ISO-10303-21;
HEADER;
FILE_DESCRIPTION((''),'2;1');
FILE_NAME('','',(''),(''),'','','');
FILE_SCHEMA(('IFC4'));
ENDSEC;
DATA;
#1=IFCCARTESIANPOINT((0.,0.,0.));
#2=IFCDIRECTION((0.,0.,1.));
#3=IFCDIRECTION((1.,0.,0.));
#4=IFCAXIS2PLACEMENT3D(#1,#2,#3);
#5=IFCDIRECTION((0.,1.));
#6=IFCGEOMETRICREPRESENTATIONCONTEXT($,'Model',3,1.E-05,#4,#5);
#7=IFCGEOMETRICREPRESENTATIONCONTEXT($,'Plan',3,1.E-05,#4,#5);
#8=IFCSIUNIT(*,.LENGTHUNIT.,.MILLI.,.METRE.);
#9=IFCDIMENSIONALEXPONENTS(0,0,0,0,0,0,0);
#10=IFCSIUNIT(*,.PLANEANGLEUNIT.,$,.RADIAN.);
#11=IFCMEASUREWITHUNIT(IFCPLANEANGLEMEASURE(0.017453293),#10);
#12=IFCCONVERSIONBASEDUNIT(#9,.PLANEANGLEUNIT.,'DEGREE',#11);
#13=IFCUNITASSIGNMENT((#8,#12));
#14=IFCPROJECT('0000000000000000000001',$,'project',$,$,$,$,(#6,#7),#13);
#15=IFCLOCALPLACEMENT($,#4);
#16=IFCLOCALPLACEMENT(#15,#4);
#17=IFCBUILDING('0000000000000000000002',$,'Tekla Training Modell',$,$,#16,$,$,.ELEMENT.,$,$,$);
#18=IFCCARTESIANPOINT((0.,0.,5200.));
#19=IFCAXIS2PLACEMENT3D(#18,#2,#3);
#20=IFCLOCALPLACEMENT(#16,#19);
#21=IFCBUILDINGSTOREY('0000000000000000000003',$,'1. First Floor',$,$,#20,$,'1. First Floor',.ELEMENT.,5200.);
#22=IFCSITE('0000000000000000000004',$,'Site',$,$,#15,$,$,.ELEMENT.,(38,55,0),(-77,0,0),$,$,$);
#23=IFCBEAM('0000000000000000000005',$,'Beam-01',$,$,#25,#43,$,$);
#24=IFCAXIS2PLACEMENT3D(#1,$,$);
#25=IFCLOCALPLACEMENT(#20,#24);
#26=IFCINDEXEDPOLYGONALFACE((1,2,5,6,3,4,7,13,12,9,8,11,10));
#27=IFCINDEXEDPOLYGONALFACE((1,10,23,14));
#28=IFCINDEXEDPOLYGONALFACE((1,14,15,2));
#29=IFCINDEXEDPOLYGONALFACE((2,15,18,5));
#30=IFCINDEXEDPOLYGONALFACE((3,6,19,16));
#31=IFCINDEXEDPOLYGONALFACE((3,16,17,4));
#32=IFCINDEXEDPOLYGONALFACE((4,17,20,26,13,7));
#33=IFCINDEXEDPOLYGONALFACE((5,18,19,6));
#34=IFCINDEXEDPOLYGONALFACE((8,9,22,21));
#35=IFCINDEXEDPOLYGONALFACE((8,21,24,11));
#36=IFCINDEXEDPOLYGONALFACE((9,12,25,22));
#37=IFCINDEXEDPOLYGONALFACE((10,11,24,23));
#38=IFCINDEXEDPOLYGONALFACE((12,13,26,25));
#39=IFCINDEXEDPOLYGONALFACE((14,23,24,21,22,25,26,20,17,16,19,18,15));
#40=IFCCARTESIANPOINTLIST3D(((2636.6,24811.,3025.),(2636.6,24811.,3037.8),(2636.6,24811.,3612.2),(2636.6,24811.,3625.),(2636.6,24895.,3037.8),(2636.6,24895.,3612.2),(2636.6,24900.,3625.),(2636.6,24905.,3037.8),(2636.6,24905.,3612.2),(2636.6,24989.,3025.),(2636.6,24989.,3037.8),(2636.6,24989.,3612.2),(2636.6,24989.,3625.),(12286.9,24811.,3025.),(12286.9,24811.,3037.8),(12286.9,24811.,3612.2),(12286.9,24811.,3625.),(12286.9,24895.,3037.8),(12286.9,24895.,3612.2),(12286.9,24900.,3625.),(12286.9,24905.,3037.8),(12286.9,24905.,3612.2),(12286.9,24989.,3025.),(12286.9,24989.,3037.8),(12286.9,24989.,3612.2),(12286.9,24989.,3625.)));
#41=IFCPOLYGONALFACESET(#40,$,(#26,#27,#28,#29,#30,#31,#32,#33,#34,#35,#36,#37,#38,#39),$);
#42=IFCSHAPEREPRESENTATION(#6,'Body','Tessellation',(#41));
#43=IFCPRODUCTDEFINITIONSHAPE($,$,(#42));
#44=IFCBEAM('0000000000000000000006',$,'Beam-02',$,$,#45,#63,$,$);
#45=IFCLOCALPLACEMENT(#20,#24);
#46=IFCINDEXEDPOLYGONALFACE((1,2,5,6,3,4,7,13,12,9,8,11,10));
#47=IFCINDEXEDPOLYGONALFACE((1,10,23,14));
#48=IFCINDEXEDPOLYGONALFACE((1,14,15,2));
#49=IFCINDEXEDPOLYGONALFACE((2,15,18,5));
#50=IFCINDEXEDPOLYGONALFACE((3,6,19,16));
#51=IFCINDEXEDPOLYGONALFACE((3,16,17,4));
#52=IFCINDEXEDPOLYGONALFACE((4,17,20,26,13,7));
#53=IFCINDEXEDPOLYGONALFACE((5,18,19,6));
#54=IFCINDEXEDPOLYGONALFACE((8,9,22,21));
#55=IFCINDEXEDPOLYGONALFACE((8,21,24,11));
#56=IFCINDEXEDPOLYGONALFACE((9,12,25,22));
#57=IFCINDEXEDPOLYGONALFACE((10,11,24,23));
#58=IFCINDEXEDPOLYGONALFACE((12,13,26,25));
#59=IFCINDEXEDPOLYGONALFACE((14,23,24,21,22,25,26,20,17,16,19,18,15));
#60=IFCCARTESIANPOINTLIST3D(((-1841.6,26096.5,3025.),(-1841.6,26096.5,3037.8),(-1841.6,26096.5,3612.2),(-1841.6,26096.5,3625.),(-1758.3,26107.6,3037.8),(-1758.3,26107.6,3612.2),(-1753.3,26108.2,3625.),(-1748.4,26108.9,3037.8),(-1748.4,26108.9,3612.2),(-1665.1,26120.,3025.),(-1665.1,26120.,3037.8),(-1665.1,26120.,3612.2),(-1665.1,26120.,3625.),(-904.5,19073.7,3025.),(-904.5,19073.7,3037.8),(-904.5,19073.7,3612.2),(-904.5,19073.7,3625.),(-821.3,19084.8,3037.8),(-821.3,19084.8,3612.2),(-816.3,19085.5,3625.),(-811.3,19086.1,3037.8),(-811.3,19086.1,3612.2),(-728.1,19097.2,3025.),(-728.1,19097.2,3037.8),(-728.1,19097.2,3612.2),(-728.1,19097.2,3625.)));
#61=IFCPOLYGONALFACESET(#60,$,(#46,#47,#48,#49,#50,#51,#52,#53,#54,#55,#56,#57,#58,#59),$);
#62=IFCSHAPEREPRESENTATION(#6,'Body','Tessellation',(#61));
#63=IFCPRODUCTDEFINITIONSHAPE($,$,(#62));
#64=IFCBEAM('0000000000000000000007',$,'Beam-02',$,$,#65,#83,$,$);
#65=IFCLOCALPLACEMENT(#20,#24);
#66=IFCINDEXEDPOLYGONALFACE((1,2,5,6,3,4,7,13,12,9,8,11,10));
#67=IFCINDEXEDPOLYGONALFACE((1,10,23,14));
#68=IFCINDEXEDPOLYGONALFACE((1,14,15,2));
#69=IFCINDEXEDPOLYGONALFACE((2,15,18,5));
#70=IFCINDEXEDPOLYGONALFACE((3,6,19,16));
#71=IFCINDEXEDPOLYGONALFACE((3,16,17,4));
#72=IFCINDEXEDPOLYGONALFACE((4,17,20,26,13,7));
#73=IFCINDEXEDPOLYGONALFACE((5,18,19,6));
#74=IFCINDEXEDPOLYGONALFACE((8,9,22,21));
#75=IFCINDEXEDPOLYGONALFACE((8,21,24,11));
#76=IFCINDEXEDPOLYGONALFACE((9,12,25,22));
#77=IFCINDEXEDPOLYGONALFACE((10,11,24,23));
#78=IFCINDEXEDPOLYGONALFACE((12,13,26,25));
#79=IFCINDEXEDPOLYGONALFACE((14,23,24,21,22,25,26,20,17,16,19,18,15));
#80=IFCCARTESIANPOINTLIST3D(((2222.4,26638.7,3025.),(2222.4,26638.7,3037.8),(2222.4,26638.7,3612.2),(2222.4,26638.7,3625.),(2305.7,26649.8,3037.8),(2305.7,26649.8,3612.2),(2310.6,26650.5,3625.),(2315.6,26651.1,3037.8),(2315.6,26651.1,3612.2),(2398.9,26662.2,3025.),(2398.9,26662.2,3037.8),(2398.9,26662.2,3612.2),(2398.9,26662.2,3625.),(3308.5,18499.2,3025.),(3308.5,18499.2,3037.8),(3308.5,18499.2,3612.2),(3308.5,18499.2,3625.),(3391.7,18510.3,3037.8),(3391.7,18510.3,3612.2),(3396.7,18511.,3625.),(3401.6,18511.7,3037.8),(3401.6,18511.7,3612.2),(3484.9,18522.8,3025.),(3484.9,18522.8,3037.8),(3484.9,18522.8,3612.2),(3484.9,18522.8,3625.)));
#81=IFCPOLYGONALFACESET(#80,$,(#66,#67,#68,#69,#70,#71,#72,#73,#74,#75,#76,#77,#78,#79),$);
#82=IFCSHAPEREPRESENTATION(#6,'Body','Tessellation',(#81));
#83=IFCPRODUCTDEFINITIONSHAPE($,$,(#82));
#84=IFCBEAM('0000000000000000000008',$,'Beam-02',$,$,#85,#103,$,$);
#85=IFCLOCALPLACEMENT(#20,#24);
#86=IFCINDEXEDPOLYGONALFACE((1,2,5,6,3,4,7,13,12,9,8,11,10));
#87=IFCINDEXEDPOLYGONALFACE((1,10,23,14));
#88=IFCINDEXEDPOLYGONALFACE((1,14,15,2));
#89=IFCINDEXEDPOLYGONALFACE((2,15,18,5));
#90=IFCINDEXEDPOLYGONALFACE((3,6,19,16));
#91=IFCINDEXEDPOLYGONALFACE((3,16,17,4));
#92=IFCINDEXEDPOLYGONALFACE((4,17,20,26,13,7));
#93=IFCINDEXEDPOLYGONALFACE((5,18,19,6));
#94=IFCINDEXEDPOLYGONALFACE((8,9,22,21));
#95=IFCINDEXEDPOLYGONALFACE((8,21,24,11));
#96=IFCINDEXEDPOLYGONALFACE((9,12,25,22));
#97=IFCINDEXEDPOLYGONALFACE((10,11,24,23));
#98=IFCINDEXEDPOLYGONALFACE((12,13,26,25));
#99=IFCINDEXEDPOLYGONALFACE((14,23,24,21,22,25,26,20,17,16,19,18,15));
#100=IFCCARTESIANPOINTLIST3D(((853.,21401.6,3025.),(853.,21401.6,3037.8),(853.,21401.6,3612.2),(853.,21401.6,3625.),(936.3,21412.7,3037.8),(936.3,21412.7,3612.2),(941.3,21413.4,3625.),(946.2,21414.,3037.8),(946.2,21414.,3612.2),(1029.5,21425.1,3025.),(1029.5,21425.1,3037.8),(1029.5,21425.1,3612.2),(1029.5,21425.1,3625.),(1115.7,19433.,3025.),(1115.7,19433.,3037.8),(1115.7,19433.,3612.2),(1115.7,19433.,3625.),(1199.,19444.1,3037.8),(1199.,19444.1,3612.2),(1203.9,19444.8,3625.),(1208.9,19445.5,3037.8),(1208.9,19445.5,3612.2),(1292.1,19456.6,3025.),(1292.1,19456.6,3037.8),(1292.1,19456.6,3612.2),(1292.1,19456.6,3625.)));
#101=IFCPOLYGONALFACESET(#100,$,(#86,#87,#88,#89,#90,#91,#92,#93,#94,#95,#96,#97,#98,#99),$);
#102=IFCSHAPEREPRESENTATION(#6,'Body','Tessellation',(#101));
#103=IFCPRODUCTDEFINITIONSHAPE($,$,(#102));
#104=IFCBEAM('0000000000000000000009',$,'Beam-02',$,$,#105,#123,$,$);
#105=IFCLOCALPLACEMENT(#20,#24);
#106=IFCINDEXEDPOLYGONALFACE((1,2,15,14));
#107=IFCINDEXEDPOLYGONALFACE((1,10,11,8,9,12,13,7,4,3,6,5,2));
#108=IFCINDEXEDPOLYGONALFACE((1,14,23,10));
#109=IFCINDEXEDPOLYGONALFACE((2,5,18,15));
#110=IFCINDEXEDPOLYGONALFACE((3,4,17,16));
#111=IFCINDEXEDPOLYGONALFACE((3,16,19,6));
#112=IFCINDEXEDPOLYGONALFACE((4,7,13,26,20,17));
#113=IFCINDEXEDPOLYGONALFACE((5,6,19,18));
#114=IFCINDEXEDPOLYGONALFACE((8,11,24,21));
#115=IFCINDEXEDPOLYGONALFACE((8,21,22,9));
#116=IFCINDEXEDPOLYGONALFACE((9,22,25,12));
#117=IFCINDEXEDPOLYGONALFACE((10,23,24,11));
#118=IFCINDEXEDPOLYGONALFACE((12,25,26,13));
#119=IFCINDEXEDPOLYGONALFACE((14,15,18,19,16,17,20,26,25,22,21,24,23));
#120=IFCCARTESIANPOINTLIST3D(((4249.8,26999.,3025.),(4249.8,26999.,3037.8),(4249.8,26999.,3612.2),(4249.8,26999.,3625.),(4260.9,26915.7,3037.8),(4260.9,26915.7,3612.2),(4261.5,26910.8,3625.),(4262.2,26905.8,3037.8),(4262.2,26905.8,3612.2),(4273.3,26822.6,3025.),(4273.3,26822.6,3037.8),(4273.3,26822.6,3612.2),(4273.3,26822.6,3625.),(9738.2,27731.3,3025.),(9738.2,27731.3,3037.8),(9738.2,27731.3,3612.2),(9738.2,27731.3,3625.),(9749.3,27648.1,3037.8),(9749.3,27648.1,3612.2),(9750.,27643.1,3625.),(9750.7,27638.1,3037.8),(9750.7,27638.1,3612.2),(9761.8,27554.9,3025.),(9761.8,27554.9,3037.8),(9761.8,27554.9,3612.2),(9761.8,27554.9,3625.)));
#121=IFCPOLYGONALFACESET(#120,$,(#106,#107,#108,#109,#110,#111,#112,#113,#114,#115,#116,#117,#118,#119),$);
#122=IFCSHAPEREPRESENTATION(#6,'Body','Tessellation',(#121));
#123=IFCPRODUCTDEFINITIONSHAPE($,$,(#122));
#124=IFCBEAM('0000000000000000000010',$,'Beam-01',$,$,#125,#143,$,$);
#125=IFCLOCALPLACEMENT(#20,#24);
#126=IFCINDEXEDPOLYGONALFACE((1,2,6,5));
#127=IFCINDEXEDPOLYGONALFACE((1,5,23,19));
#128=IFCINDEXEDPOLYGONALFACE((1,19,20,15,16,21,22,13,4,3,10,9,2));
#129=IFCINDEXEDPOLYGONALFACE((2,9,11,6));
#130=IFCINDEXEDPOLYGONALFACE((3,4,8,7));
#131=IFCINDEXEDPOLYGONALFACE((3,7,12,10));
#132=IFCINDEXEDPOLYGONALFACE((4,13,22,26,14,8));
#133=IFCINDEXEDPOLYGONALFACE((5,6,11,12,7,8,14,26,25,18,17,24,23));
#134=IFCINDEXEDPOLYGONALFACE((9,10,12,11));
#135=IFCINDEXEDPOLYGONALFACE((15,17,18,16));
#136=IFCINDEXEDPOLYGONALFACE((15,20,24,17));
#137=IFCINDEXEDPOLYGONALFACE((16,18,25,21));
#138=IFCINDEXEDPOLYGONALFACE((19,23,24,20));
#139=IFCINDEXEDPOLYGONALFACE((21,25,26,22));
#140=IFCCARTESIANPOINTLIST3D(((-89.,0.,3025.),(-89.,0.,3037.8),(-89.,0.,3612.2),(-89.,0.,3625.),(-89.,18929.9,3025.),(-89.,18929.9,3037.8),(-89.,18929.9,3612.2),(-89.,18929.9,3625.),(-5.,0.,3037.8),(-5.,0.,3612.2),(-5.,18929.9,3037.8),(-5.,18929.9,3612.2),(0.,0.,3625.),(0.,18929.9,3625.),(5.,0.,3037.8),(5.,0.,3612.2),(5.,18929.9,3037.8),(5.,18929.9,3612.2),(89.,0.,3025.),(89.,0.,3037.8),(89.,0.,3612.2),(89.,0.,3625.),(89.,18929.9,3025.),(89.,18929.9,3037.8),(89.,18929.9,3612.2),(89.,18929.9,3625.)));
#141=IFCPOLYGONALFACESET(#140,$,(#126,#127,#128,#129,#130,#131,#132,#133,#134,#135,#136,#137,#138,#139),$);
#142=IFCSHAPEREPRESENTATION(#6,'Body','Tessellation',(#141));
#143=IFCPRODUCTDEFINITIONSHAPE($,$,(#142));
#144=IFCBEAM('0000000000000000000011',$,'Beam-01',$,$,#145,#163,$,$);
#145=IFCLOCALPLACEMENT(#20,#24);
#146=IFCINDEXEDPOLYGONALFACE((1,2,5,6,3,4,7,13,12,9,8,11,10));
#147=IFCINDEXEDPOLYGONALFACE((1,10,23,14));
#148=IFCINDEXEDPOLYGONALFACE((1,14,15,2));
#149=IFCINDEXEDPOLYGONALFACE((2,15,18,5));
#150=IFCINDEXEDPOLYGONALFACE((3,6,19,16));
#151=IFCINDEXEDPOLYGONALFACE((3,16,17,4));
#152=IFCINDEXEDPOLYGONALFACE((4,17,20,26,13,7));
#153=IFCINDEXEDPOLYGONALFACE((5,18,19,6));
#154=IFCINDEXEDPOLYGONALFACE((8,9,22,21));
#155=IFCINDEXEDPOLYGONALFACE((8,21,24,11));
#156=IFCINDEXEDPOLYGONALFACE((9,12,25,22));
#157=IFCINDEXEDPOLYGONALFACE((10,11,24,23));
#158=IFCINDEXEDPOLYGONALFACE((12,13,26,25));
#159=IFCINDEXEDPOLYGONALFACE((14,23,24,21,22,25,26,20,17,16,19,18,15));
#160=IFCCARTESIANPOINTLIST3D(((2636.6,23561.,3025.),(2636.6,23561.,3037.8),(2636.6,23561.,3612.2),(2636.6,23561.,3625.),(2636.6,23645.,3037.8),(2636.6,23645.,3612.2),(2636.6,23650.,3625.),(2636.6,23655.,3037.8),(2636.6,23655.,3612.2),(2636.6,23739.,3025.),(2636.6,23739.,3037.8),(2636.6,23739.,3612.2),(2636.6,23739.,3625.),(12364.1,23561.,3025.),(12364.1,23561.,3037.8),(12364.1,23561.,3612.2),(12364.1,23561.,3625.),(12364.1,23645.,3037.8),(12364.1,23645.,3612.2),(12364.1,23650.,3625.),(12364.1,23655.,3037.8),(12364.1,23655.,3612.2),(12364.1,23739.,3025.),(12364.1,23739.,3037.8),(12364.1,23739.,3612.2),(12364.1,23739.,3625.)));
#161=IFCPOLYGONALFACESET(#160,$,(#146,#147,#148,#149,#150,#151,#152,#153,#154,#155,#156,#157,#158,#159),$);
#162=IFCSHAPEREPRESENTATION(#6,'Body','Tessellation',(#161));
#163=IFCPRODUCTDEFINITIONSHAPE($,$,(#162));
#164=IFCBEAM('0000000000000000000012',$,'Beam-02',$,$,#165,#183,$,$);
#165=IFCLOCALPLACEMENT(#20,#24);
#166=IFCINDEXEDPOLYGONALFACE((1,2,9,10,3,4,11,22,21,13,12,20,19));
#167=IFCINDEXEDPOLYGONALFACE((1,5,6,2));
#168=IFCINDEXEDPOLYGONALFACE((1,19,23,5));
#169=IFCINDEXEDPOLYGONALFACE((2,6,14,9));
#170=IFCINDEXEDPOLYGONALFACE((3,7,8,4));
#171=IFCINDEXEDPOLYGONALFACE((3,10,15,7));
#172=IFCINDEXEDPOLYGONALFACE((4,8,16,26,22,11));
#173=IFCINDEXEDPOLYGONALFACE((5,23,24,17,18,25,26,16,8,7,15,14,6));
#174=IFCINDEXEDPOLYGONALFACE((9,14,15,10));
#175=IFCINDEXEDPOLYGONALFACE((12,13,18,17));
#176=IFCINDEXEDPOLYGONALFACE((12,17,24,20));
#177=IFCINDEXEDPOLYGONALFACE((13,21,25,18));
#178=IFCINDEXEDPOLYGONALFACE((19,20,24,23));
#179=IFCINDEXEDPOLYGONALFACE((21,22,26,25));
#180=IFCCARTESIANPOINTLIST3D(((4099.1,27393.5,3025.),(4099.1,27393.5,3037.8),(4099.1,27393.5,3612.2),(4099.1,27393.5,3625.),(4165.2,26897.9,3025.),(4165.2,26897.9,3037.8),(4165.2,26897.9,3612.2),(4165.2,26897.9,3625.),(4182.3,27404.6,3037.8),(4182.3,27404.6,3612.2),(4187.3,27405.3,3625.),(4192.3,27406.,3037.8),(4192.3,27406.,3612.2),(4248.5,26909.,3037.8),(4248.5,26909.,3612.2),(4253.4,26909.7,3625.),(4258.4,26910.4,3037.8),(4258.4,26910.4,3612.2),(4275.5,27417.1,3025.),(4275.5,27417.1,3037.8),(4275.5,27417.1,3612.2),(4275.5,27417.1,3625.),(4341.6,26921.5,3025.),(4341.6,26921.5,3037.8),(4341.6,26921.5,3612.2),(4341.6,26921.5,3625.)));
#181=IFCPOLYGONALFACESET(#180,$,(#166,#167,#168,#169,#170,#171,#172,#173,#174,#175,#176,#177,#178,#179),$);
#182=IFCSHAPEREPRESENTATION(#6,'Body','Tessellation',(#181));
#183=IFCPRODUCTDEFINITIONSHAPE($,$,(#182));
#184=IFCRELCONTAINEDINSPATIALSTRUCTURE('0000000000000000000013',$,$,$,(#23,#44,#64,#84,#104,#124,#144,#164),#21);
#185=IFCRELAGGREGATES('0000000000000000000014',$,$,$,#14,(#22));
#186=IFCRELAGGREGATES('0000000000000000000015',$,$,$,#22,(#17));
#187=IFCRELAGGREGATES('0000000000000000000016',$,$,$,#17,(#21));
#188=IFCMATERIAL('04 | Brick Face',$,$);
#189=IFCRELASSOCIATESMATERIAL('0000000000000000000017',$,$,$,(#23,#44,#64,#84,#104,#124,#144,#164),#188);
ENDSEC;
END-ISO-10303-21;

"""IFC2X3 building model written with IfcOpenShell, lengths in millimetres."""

from ifc_helpers import new_model, entity, si_unit, converted_unit, direction, frame, origin_with_axes, place, context, project, spatial, polyline, outline, extrude, material, element, save


model = new_model("IFC2X3")

# Units and contexts
model_context = context("Model", 3, precision=1e-05, world=origin_with_axes(), true_north=direction((0.0, 1.0)))
plan_context = context("Plan", 3, precision=1e-05, world=origin_with_axes(), true_north=direction((0.0, 1.0)))
ifc_project = project(units=[si_unit("LENGTHUNIT", "METRE", prefix="MILLI"), converted_unit("PLANEANGLEUNIT", "DEGREE", entity("IfcPlaneAngleMeasure", 0.017453293), si_unit("PLANEANGLEUNIT", "RADIAN"), dimensions=[0, 0, 0, 0, 0, 0, 0])], contexts=[model_context, plan_context])

# Site, building, storey
site_placement = place(None, origin_with_axes())
site = spatial("IfcSite", under=ifc_project, at=site_placement, Name="Site", CompositionType="ELEMENT", RefLatitude=(38, 55, 0), RefLongitude=(-77, 0, 0))
building_placement = place(site_placement, origin_with_axes())
building = spatial("IfcBuilding", under=site, at=building_placement, Name="Tekla Training Modell", CompositionType="ELEMENT")
storey_placement = place(building_placement, frame((0.0, 0.0, 5200.0), z_axis=(0.0, 0.0, 1.0), x_axis=(1.0, 0.0, 0.0)))
storey = spatial("IfcBuildingStorey", under=building, at=storey_placement, Name="1. First Floor", LongName="1. First Floor", CompositionType="ELEMENT", Elevation=5200.0)

# Shared definitions
ifc_material_1 = material(Name="04 | Brick Face")

# Beams
beam_1_placement = place(storey_placement, frame((2636.6, 24900.0, 3325.0), z_axis=(0.0, 0.0, 1.0), x_axis=(0.0, -1.0, 0.0)))
element("IfcBeam", 1, at=beam_1_placement, inside=storey, material=ifc_material_1, Name="Beam-01", context=model_context, shape_type="SweptSolid", body=[
    extrude(outline(polyline([(0.0, 300.0), (-89.0, 300.0), (-89.0, 287.2), (-5.0, 287.2), (-5.0, -287.2), (-89.0, -287.2), (-89.0, -300.0), (89.0, -300.0), (89.0, -287.2), (5.0, -287.2), (5.0, 287.2), (89.0, 287.2), (89.0, 300.0), (0.0, 300.0)])), frame((0.0, 9650.3, 0.0), z_axis=(0.0, -1.0, 0.0), x_axis=(1.0, 0.0, 0.0)), (0.0, 0.0, 1.0), 9650.3),
])
beam_2_placement = place(storey_placement, frame((-1753.3, 26108.2, 3325.0), z_axis=(0.0, 0.0, 1.0), x_axis=(-0.991216, -0.132256, 0.0)))
element("IfcBeam", 2, at=beam_2_placement, inside=storey, material=ifc_material_1, Name="Beam-02", context=model_context, shape_type="SweptSolid", body=[
    extrude(outline(polyline([(0.0, 300.0), (-89.0, 300.0), (-89.0, 287.2), (-5.0, 287.2), (-5.0, -287.2), (-89.0, -287.2), (-89.0, -300.0), (89.0, -300.0), (89.0, -287.2), (5.0, -287.2), (5.0, 287.2), (89.0, 287.2), (89.0, 300.0), (0.0, 300.0)])), frame((0.0, 7085.0, 0.0), z_axis=(0.0, -1.0, 0.0), x_axis=(1.0, 0.0, 0.0)), (0.0, 0.0, 1.0), 7085.0),
])
beam_3_placement = place(storey_placement, frame((2310.6, 26650.5, 3325.0), z_axis=(0.0, 0.0, 1.0), x_axis=(-0.991216, -0.132256, 0.0)))
element("IfcBeam", 3, at=beam_3_placement, inside=storey, material=ifc_material_1, Name="Beam-02", context=model_context, shape_type="SweptSolid", body=[
    extrude(outline(polyline([(0.0, 300.0), (-89.0, 300.0), (-89.0, 287.2), (-5.0, 287.2), (-5.0, -287.2), (-89.0, -287.2), (-89.0, -300.0), (89.0, -300.0), (89.0, -287.2), (5.0, -287.2), (5.0, 287.2), (89.0, 287.2), (89.0, 300.0), (0.0, 300.0)])), frame((0.0, 8211.6, 0.0), z_axis=(0.0, -1.0, 0.0), x_axis=(1.0, 0.0, 0.0)), (0.0, 0.0, 1.0), 8211.6),
])
beam_4_placement = place(storey_placement, frame((941.3, 21413.4, 3325.0), z_axis=(0.0, 0.0, 1.0), x_axis=(-0.991216, -0.132256, 0.0)))
element("IfcBeam", 4, at=beam_4_placement, inside=storey, material=ifc_material_1, Name="Beam-02", context=model_context, shape_type="SweptSolid", body=[
    extrude(outline(polyline([(0.0, 300.0), (-89.0, 300.0), (-89.0, 287.2), (-5.0, 287.2), (-5.0, -287.2), (-89.0, -287.2), (-89.0, -300.0), (89.0, -300.0), (89.0, -287.2), (5.0, -287.2), (5.0, 287.2), (89.0, 287.2), (89.0, 300.0), (0.0, 300.0)])), frame((0.0, 1986.0, 0.0), z_axis=(0.0, -1.0, 0.0), x_axis=(1.0, 0.0, 0.0)), (0.0, 0.0, 1.0), 1986.0),
])
beam_5_placement = place(storey_placement, frame((4261.5, 26910.8, 3325.0), z_axis=(0.0, 0.0, 1.0), x_axis=(0.132256, -0.991216, 0.0)))
element("IfcBeam", 5, at=beam_5_placement, inside=storey, material=ifc_material_1, Name="Beam-02", context=model_context, shape_type="SweptSolid", body=[
    extrude(outline(polyline([(0.0, 300.0), (-89.0, 300.0), (-89.0, 287.2), (-5.0, 287.2), (-5.0, -287.2), (-89.0, -287.2), (-89.0, -300.0), (89.0, -300.0), (89.0, -287.2), (5.0, -287.2), (5.0, 287.2), (89.0, 287.2), (89.0, 300.0), (0.0, 300.0)])), frame((0.0, 5537.1, 0.0), z_axis=(0.0, -1.0, 0.0), x_axis=(1.0, 0.0, 0.0)), (0.0, 0.0, 1.0), 5537.1),
])
beam_6_placement = place(storey_placement, frame((0.0, 18929.9, 3325.0), z_axis=(0.0, 0.0, 1.0), x_axis=(-1.0, 0.0, 0.0)))
element("IfcBeam", 6, at=beam_6_placement, inside=storey, material=ifc_material_1, Name="Beam-01", context=model_context, shape_type="SweptSolid", body=[
    extrude(outline(polyline([(0.0, 300.0), (-89.0, 300.0), (-89.0, 287.2), (-5.0, 287.2), (-5.0, -287.2), (-89.0, -287.2), (-89.0, -300.0), (89.0, -300.0), (89.0, -287.2), (5.0, -287.2), (5.0, 287.2), (89.0, 287.2), (89.0, 300.0), (0.0, 300.0)])), frame((0.0, 18929.9, 0.0), z_axis=(0.0, -1.0, 0.0), x_axis=(1.0, 0.0, 0.0)), (0.0, 0.0, 1.0), 18929.9),
])
beam_7_placement = place(storey_placement, frame((2636.6, 23650.0, 3325.0), z_axis=(0.0, 0.0, 1.0), x_axis=(0.0, -1.0, 0.0)))
element("IfcBeam", 7, at=beam_7_placement, inside=storey, material=ifc_material_1, Name="Beam-01", context=model_context, shape_type="SweptSolid", body=[
    extrude(outline(polyline([(0.0, 300.0), (-89.0, 300.0), (-89.0, 287.2), (-5.0, 287.2), (-5.0, -287.2), (-89.0, -287.2), (-89.0, -300.0), (89.0, -300.0), (89.0, -287.2), (5.0, -287.2), (5.0, 287.2), (89.0, 287.2), (89.0, 300.0), (0.0, 300.0)])), frame((0.0, 9727.5, 0.0), z_axis=(0.0, -1.0, 0.0), x_axis=(1.0, 0.0, 0.0)), (0.0, 0.0, 1.0), 9727.5),
])
beam_8_placement = place(storey_placement, frame((4187.3, 27405.3, 3325.0), z_axis=(0.0, 0.0, 1.0), x_axis=(-0.991216, -0.132256, 0.0)))
element("IfcBeam", 8, at=beam_8_placement, inside=storey, material=ifc_material_1, Name="Beam-02", context=model_context, shape_type="SweptSolid", body=[
    extrude(outline(polyline([(0.0, 300.0), (-89.0, 300.0), (-89.0, 287.2), (-5.0, 287.2), (-5.0, -287.2), (-89.0, -287.2), (-89.0, -300.0), (89.0, -300.0), (89.0, -287.2), (5.0, -287.2), (5.0, 287.2), (89.0, 287.2), (89.0, 300.0), (0.0, 300.0)])), frame((0.0, 500.0, 0.0), z_axis=(0.0, -1.0, 0.0), x_axis=(1.0, 0.0, 0.0)), (0.0, 0.0, 1.0), 500.0),
])

save(model, "model.ifc")
